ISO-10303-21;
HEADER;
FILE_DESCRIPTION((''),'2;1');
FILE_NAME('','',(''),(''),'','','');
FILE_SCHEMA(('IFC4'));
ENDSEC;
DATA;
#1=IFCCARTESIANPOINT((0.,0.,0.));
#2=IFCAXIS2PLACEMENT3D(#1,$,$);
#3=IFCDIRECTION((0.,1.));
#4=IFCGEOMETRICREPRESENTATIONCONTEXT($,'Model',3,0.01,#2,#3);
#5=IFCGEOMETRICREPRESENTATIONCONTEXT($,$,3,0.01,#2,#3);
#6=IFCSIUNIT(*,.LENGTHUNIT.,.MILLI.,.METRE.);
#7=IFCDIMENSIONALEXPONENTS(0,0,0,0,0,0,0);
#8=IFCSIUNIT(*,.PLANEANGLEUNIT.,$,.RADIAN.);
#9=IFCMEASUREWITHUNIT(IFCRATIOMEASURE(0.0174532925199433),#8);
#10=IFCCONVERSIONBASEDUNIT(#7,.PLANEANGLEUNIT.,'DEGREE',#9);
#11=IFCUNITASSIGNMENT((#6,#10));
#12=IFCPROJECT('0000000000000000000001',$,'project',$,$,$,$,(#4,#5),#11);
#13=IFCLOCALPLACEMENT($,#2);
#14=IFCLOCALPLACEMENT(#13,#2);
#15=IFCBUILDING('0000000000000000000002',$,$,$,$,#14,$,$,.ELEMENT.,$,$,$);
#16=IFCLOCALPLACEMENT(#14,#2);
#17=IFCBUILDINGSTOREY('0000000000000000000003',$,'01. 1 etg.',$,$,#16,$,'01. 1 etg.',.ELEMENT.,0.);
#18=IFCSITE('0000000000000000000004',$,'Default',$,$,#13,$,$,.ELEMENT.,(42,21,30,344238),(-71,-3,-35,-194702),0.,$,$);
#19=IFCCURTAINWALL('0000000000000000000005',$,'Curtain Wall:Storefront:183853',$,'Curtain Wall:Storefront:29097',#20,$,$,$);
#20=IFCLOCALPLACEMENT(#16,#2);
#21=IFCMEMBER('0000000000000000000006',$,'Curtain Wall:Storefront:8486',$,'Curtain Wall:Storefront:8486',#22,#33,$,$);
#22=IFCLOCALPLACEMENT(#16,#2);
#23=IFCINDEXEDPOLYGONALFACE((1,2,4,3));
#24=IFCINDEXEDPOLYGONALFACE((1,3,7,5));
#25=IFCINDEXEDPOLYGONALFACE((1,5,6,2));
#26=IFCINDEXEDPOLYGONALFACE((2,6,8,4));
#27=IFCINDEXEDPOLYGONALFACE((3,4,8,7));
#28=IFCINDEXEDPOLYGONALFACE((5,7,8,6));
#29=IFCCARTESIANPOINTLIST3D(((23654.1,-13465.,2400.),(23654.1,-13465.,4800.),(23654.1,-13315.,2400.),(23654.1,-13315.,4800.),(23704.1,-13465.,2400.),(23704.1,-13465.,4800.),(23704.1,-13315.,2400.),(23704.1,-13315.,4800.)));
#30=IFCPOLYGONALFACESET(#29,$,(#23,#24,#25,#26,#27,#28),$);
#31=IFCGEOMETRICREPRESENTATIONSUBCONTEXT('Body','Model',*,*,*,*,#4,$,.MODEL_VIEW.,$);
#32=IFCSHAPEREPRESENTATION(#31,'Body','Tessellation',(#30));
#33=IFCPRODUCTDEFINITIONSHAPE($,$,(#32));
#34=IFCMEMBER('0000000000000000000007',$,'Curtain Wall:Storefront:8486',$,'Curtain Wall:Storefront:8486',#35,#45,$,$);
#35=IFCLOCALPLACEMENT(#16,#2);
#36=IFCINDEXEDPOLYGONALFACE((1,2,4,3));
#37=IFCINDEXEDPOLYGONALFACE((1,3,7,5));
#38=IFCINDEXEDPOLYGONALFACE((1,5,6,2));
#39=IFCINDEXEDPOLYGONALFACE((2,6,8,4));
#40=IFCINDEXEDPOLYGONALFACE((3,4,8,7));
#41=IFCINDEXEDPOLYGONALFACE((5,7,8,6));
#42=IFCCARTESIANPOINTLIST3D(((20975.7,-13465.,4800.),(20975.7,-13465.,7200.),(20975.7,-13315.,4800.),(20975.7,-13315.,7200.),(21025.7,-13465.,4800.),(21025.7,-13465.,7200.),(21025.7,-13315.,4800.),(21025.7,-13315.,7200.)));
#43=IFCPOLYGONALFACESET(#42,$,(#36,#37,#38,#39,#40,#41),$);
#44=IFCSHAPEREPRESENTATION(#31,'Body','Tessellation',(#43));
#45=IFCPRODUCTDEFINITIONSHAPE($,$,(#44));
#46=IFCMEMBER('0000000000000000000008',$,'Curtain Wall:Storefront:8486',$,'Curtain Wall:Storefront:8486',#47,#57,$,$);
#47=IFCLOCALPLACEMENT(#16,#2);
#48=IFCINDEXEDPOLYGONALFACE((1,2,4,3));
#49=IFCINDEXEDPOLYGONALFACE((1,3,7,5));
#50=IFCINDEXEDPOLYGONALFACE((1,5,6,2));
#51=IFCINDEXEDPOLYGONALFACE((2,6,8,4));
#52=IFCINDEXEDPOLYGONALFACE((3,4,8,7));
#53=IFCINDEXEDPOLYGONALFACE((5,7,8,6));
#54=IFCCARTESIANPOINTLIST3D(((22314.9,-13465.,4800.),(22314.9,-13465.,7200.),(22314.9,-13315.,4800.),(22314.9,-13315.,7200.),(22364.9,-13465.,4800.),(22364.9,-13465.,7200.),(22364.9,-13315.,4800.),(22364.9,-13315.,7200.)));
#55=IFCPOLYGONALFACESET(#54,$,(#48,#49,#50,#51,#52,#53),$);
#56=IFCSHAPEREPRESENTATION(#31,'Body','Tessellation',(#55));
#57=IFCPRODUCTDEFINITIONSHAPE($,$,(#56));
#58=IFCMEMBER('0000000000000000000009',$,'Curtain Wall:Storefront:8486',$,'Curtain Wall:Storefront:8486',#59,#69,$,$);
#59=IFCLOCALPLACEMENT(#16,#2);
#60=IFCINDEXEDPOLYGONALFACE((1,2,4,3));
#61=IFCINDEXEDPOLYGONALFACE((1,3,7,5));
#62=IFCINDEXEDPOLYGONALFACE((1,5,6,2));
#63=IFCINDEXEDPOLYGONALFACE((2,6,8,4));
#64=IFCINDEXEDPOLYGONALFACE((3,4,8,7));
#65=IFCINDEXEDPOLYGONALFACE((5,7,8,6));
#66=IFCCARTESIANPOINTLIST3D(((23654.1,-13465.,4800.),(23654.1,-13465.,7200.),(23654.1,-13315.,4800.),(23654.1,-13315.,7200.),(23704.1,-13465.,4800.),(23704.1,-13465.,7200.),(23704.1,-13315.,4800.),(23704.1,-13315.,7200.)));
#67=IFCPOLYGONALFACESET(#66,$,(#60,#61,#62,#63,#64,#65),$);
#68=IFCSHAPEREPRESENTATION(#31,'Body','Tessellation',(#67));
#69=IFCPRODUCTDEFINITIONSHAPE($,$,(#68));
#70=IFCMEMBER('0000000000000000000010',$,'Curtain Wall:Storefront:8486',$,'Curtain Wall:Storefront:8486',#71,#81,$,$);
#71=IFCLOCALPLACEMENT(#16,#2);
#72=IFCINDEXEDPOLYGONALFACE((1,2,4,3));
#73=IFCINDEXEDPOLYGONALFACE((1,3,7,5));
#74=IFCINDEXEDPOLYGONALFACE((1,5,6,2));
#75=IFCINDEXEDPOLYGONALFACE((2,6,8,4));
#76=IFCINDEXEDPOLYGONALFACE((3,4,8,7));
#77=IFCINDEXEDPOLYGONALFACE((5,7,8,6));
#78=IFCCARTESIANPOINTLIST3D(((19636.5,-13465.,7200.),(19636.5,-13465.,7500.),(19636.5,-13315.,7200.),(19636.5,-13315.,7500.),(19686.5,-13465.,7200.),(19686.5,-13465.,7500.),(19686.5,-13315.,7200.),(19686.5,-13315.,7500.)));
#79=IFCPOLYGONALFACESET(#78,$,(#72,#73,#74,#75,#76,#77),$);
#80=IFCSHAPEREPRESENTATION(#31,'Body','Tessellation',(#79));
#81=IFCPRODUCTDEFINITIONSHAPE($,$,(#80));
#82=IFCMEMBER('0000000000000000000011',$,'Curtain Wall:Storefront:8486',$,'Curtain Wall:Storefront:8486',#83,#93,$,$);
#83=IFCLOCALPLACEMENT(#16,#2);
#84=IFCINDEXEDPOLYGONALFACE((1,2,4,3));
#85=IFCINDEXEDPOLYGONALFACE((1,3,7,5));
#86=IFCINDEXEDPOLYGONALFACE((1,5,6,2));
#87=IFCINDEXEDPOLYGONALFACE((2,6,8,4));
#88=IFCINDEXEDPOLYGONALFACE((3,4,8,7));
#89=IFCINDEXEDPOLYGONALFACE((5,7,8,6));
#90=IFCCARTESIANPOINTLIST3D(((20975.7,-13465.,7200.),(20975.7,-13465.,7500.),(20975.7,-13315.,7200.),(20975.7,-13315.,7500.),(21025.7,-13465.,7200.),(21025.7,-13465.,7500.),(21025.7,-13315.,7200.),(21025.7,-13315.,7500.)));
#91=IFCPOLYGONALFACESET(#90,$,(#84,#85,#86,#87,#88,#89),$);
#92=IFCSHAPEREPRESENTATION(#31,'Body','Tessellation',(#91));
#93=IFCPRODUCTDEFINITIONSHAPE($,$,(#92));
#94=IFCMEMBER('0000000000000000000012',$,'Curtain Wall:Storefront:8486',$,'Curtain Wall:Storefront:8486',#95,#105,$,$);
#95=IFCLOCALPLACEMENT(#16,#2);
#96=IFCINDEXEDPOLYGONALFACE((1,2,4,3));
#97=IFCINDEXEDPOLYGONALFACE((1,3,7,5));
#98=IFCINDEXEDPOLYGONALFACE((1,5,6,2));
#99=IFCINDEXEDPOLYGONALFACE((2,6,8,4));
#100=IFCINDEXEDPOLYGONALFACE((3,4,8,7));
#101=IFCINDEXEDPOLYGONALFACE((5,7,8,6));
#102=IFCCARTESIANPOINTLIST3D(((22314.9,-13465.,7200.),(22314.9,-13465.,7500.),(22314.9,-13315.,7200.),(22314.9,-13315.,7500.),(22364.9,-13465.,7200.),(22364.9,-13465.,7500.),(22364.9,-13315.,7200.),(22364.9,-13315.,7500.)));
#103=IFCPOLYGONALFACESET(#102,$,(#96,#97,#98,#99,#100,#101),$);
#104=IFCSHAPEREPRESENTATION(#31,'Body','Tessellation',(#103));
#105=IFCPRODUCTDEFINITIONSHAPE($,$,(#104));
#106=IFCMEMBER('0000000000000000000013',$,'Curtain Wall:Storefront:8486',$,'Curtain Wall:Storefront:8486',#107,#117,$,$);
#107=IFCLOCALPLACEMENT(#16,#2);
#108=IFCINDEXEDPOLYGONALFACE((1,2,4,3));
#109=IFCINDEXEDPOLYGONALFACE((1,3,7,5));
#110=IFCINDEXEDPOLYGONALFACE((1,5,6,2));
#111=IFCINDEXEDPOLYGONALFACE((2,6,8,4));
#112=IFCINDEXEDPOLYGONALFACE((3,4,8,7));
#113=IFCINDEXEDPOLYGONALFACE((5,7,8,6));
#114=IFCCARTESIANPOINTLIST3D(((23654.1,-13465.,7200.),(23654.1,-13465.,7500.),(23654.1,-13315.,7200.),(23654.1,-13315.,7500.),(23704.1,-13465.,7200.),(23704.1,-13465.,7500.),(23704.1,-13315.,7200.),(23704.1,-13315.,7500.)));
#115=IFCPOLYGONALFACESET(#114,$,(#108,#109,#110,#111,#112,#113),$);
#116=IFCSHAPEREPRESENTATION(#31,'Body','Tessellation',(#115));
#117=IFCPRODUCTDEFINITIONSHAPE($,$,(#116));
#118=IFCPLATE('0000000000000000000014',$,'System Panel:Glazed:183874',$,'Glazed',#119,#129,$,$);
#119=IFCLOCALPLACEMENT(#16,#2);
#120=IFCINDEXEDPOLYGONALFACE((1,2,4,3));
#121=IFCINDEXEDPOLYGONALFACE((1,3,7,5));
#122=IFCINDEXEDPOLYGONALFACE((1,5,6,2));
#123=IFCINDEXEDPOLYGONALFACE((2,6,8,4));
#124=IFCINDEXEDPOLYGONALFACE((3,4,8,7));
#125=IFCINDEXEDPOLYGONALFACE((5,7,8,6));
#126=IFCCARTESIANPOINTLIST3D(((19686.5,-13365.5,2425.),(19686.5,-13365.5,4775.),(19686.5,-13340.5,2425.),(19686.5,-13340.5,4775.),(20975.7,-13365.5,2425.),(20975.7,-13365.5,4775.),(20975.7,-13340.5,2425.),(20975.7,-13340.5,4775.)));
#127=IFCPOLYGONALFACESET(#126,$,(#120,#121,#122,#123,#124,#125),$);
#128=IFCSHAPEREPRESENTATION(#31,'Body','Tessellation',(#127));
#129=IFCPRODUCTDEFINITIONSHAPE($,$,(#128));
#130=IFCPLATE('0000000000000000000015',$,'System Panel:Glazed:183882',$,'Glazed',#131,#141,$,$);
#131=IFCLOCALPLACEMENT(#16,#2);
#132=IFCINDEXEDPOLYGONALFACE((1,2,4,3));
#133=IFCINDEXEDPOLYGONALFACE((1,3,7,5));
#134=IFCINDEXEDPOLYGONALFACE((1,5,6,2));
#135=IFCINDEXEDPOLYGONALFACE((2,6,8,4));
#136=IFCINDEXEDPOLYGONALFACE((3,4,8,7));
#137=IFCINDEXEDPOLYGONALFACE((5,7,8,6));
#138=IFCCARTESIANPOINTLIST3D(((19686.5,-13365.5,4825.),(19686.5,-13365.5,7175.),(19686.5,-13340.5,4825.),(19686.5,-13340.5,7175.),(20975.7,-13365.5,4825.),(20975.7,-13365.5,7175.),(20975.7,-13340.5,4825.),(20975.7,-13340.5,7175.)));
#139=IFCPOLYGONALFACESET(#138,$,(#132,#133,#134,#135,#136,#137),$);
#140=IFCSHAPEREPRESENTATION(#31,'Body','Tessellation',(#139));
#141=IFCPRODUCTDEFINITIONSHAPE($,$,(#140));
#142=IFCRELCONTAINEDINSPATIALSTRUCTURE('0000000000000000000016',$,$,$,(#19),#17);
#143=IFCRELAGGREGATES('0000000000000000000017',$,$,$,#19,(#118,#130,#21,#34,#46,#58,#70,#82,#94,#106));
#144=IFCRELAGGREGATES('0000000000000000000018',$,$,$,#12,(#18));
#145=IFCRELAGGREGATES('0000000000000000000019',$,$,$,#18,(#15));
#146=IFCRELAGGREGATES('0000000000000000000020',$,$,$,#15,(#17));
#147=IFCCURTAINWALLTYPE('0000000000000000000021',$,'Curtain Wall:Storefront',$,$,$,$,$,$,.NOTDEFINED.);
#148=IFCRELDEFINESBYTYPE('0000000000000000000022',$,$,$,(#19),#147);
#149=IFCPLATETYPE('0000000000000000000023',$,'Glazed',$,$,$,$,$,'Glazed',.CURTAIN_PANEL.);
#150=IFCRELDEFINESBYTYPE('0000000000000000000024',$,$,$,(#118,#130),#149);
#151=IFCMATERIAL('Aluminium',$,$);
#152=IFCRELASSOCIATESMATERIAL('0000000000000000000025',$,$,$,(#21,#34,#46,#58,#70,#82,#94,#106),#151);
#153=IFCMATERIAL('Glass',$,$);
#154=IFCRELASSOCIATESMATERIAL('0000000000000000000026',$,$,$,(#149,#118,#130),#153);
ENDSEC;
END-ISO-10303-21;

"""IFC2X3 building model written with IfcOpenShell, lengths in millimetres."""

from ifc_helpers import new_model, entity, si_unit, converted_unit, direction, frame, frame_2d, origin, origin_2d_with_axis, place, context, subcontext, project, spatial, rectangle, extrude, source, transform, mapped, material, type_object, type_shapes, element, aggregate, save


model = new_model("IFC2X3")

# Units and contexts
model_context = context("Model", 3, precision=0.01, world=origin(), true_north=direction((0.0, 1.0)))
context_of_model = context(None, 3, precision=0.01, world=origin(), true_north=direction((0.0, 1.0)))
body_context = subcontext(model_context, "Body", "Model", "MODEL_VIEW")
ifc_project = project(units=[si_unit("LENGTHUNIT", "METRE", prefix="MILLI"), converted_unit("PLANEANGLEUNIT", "DEGREE", entity("IfcRatioMeasure", 0.0174532925199433), si_unit("PLANEANGLEUNIT", "RADIAN"), dimensions=[0, 0, 0, 0, 0, 0, 0])], contexts=[model_context, context_of_model])

# Site, building, storey
site_placement = place(None, origin())
site = spatial("IfcSite", under=ifc_project, at=site_placement, Name="Default", CompositionType="ELEMENT", RefLatitude=(42, 21, 30, 344238), RefLongitude=(-71, -3, -35, -194702), RefElevation=0.0)
building_placement = place(site_placement, origin())
building = spatial("IfcBuilding", under=site, at=building_placement, CompositionType="ELEMENT")
storey_placement = place(building_placement, origin())
storey = spatial("IfcBuildingStorey", under=building, at=storey_placement, Name="01. 1 etg.", LongName="01. 1 etg.", CompositionType="ELEMENT", Elevation=0.0)

# Curtain wall, members, plates
curtain_wall_type = type_object("IfcCurtainWallType", Name="Curtain Wall:Storefront", PredefinedType="NOTDEFINED")
curtain_wall_placement = place(storey_placement, origin())
curtain_wall = element("IfcCurtainWall", 1, at=curtain_wall_placement, inside=storey, type_object=curtain_wall_type, Name="Curtain Wall:Storefront:183853", ObjectType="Curtain Wall:Storefront:29097")
ifc_material_1 = material(Name="Aluminium")
member_1_placement = place(curtain_wall_placement, frame((23654.1, -13465.0, 2400.0)))
member_1 = element("IfcMember", 2, at=member_1_placement, material=ifc_material_1, Name="Curtain Wall:Storefront:8486", ObjectType="Curtain Wall:Storefront:8486", context=body_context, shape_type="SweptSolid", body=[
    extrude(rectangle(XDim=150.0, YDim=50.0, at=frame_2d((0.0, 0.0), x_axis=(1.0, 0.0))), frame((25.0, 75.0, 0.0), z_axis=(0.0, 0.0, 1.0), x_axis=(0.0, 1.0, 0.0)), (0.0, 0.0, 1.0), 2400.0),
])
member_2_placement = place(curtain_wall_placement, frame((20975.7, -13465.0, 4800.0)))
member_2 = element("IfcMember", 3, at=member_2_placement, material=ifc_material_1, Name="Curtain Wall:Storefront:8486", ObjectType="Curtain Wall:Storefront:8486", context=body_context, shape_type="SweptSolid", body=[
    extrude(rectangle(XDim=150.0, YDim=50.0, at=frame_2d((0.0, 0.0), x_axis=(1.0, 0.0))), frame((25.0, 75.0, 0.0), z_axis=(0.0, 0.0, 1.0), x_axis=(0.0, 1.0, 0.0)), (0.0, 0.0, 1.0), 2400.0),
])
member_3_placement = place(curtain_wall_placement, frame((22314.9, -13465.0, 4800.0)))
member_3 = element("IfcMember", 4, at=member_3_placement, material=ifc_material_1, Name="Curtain Wall:Storefront:8486", ObjectType="Curtain Wall:Storefront:8486", context=body_context, shape_type="SweptSolid", body=[
    extrude(rectangle(XDim=150.0, YDim=50.0, at=frame_2d((0.0, 0.0), x_axis=(1.0, 0.0))), frame((25.0, 75.0, 0.0), z_axis=(0.0, 0.0, 1.0), x_axis=(0.0, 1.0, 0.0)), (0.0, 0.0, 1.0), 2400.0),
])
member_4_placement = place(curtain_wall_placement, frame((23654.1, -13465.0, 4800.0)))
member_4 = element("IfcMember", 5, at=member_4_placement, material=ifc_material_1, Name="Curtain Wall:Storefront:8486", ObjectType="Curtain Wall:Storefront:8486", context=body_context, shape_type="SweptSolid", body=[
    extrude(rectangle(XDim=150.0, YDim=50.0, at=frame_2d((0.0, 0.0), x_axis=(1.0, 0.0))), frame((25.0, 75.0, 0.0), z_axis=(0.0, 0.0, 1.0), x_axis=(0.0, 1.0, 0.0)), (0.0, 0.0, 1.0), 2400.0),
])
member_5_placement = place(curtain_wall_placement, frame((19636.5, -13465.0, 7200.0)))
member_5 = element("IfcMember", 6, at=member_5_placement, material=ifc_material_1, Name="Curtain Wall:Storefront:8486", ObjectType="Curtain Wall:Storefront:8486", context=body_context, shape_type="SweptSolid", body=[
    extrude(rectangle(XDim=150.0, YDim=50.0, at=frame_2d((0.0, 0.0), x_axis=(1.0, 0.0))), frame((25.0, 75.0, 0.0), z_axis=(0.0, 0.0, 1.0), x_axis=(0.0, 1.0, 0.0)), (0.0, 0.0, 1.0), 300.0),
])
member_6_placement = place(curtain_wall_placement, frame((20975.7, -13465.0, 7200.0)))
member_6 = element("IfcMember", 7, at=member_6_placement, material=ifc_material_1, Name="Curtain Wall:Storefront:8486", ObjectType="Curtain Wall:Storefront:8486", context=body_context, shape_type="SweptSolid", body=[
    extrude(rectangle(XDim=150.0, YDim=50.0, at=frame_2d((0.0, 0.0), x_axis=(1.0, 0.0))), frame((25.0, 75.0, 0.0), z_axis=(0.0, 0.0, 1.0), x_axis=(0.0, 1.0, 0.0)), (0.0, 0.0, 1.0), 300.0),
])
member_7_placement = place(curtain_wall_placement, frame((22314.9, -13465.0, 7200.0)))
member_7 = element("IfcMember", 8, at=member_7_placement, material=ifc_material_1, Name="Curtain Wall:Storefront:8486", ObjectType="Curtain Wall:Storefront:8486", context=body_context, shape_type="SweptSolid", body=[
    extrude(rectangle(XDim=150.0, YDim=50.0, at=frame_2d((0.0, 0.0), x_axis=(1.0, 0.0))), frame((25.0, 75.0, 0.0), z_axis=(0.0, 0.0, 1.0), x_axis=(0.0, 1.0, 0.0)), (0.0, 0.0, 1.0), 300.0),
])
member_8_placement = place(curtain_wall_placement, frame((23654.1, -13465.0, 7200.0)))
member_8 = element("IfcMember", 9, at=member_8_placement, material=ifc_material_1, Name="Curtain Wall:Storefront:8486", ObjectType="Curtain Wall:Storefront:8486", context=body_context, shape_type="SweptSolid", body=[
    extrude(rectangle(XDim=150.0, YDim=50.0, at=frame_2d((0.0, 0.0), x_axis=(1.0, 0.0))), frame((25.0, 75.0, 0.0), z_axis=(0.0, 0.0, 1.0), x_axis=(0.0, 1.0, 0.0)), (0.0, 0.0, 1.0), 300.0),
])
ifc_material_2 = material(Name="Glass")
plate_type = type_object("IfcPlateType", Name="Glazed", ElementType="Glazed", PredefinedType="CURTAIN_PANEL", material=ifc_material_2)
shared_shape_1 = source(origin(), body_context, "Body", "SweptSolid", [
    extrude(rectangle(XDim=25.0, YDim=1289.2, at=origin_2d_with_axis()), frame((644.6, 12.5, 0.0), z_axis=(0.0, 0.0, 1.0), x_axis=(0.0, 1.0, 0.0)), (0.0, 0.0, 1.0), 2350.0),
])
type_shapes(plate_type, [shared_shape_1])
plate_1_placement = place(curtain_wall_placement, frame((19686.5, -13365.5, 2425.0)))
plate_1 = element("IfcPlate", 10, at=plate_1_placement, type_object=plate_type, material=ifc_material_2, Name="System Panel:Glazed:183874", ObjectType="Glazed", context=body_context, shape_type="MappedRepresentation", body=[
    mapped(shared_shape_1, transform((0.0, 0.0, 0.0), scale=1.0)),
])
plate_2_placement = place(curtain_wall_placement, frame((19686.5, -13365.5, 4825.0)))
plate_2 = element("IfcPlate", 11, at=plate_2_placement, type_object=plate_type, material=ifc_material_2, Name="System Panel:Glazed:183882", ObjectType="Glazed", context=body_context, shape_type="MappedRepresentation", body=[
    mapped(shared_shape_1, transform((0.0, 0.0, 0.0), scale=1.0)),
])
aggregate(curtain_wall, [plate_1, plate_2, member_1, member_2, member_3, member_4, member_5, member_6, member_7, member_8])

save(model, "model.ifc")
